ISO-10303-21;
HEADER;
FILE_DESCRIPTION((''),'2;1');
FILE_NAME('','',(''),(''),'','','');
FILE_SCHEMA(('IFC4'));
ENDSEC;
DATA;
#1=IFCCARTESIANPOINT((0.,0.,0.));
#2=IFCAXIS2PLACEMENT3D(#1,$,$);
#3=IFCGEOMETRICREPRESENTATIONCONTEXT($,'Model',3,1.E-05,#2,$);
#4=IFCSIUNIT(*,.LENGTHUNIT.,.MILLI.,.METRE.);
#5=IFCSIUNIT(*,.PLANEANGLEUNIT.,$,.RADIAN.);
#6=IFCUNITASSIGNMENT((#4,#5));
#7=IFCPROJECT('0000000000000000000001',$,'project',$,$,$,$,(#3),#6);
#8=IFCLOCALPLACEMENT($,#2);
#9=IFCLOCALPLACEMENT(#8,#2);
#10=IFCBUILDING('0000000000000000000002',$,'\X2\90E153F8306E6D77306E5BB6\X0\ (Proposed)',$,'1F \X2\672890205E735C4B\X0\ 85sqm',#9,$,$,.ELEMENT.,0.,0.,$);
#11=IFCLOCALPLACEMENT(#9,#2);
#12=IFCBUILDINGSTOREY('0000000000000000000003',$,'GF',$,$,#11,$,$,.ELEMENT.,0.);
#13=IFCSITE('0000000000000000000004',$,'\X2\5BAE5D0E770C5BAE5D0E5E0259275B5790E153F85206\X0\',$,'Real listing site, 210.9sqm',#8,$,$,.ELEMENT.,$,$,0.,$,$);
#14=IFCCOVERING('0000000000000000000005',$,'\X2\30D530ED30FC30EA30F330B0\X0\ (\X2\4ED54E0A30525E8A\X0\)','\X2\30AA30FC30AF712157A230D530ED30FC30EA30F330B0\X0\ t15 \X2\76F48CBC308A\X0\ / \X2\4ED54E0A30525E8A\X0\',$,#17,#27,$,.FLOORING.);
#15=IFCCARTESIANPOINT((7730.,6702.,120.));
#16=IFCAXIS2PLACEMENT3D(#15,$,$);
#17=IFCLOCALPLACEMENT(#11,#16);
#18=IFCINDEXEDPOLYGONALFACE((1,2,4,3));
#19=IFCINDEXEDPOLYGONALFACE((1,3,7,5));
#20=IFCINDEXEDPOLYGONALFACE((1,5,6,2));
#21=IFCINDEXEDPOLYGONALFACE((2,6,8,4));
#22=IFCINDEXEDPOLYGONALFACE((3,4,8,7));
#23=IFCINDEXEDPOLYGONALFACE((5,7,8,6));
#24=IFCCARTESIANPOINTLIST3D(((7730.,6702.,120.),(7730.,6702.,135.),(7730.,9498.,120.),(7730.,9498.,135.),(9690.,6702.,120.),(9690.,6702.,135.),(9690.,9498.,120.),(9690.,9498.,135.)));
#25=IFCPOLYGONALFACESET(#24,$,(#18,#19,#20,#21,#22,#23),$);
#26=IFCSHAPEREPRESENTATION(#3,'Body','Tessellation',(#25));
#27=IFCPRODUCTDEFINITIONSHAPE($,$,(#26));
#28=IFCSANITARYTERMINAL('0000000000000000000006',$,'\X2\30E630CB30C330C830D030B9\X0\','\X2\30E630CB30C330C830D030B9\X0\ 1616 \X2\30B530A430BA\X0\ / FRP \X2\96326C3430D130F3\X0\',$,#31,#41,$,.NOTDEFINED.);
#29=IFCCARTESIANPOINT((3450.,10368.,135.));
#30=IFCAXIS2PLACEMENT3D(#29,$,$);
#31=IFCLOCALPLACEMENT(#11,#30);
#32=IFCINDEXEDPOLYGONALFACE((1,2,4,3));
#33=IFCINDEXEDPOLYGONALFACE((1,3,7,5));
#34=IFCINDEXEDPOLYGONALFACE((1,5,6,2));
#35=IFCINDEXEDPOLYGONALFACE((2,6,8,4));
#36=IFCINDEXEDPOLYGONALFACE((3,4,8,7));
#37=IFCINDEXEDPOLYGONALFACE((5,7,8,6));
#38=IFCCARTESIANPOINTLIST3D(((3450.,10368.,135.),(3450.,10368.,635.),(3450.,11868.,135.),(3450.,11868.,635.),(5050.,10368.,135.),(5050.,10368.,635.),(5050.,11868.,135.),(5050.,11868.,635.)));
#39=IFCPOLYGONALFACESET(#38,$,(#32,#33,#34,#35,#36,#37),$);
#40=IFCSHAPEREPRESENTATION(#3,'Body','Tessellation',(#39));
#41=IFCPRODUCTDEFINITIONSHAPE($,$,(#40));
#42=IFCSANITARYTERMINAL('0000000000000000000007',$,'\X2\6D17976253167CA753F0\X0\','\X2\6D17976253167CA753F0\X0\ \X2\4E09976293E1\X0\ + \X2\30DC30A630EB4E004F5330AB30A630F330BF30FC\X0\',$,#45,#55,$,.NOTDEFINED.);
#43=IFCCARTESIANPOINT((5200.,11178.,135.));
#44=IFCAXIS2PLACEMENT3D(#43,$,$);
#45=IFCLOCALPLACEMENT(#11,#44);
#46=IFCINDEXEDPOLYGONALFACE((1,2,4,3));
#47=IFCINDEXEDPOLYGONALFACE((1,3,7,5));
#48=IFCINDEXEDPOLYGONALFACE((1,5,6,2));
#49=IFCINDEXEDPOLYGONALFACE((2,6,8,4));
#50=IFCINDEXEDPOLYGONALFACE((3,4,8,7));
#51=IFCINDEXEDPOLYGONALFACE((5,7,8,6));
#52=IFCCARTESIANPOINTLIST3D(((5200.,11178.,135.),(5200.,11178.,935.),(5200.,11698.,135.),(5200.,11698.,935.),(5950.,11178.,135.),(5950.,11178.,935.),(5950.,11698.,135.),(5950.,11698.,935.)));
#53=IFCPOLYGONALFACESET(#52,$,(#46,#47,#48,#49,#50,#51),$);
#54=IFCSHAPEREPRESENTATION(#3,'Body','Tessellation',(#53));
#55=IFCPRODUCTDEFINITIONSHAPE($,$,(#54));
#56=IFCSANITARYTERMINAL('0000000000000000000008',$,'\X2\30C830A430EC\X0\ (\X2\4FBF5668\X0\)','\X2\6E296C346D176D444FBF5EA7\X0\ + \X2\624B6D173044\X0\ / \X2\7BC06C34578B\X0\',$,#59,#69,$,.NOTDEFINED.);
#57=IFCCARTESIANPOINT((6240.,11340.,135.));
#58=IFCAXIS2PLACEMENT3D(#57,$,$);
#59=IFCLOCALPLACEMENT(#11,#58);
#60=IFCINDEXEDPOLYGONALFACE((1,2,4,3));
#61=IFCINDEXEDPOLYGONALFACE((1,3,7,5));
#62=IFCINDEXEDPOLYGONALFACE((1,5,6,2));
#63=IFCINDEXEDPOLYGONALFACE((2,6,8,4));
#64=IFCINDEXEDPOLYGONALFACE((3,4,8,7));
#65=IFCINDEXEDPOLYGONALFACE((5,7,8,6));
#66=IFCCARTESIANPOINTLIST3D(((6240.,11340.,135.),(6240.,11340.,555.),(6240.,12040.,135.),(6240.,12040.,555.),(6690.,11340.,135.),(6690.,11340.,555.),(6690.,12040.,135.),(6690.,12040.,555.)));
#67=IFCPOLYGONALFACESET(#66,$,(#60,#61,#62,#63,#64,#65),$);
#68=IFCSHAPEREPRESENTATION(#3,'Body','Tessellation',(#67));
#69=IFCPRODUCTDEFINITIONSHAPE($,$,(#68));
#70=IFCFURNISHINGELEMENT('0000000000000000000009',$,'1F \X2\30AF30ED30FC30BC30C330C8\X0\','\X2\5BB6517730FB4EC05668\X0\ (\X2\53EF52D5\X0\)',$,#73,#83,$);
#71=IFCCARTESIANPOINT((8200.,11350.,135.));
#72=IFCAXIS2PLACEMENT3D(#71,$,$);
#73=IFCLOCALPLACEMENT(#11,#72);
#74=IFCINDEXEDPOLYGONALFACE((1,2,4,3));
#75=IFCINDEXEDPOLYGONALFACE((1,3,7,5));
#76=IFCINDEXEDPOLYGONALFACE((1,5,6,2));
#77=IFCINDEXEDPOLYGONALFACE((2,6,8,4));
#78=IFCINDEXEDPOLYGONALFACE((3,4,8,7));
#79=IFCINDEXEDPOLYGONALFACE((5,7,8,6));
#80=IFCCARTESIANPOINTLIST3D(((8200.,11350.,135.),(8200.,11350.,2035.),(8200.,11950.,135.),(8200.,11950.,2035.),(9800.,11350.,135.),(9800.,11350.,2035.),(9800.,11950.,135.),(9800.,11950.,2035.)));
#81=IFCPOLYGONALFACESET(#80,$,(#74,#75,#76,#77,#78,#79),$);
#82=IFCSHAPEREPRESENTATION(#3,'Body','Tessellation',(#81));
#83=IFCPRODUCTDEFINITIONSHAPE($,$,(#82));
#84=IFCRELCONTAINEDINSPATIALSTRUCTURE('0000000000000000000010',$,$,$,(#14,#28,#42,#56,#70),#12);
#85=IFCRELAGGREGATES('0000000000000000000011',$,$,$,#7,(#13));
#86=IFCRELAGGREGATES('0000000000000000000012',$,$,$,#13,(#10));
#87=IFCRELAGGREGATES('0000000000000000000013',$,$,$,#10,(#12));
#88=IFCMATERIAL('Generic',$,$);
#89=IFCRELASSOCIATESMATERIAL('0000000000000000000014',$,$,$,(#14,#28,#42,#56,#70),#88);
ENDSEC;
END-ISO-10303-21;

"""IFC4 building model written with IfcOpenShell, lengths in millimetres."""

from ifc_helpers import new_model, si_unit, frame, frame_2d, origin, place, context, project, spatial, rectangle, extrude, material, element, save


model = new_model("IFC4")

# Units and contexts
model_context = context("Model", 3, precision=1e-05, world=origin())
ifc_project = project(units=[si_unit("LENGTHUNIT", "METRE", prefix="MILLI"), si_unit("PLANEANGLEUNIT", "RADIAN")], contexts=[model_context])

# Site, building, storey
site_placement = place(None, origin())
site = spatial("IfcSite", under=ifc_project, at=site_placement, Name="宮崎県宮崎市大字郡司分", ObjectType="Real listing site, 210.9sqm", CompositionType="ELEMENT", RefElevation=0.0)
building_placement = place(site_placement, origin())
building = spatial("IfcBuilding", under=site, at=building_placement, Name="郡司の海の家 (Proposed)", ObjectType="1F 木造平屋 85sqm", CompositionType="ELEMENT", ElevationOfRefHeight=0.0, ElevationOfTerrain=0.0)
storey_placement = place(building_placement, origin())
storey = spatial("IfcBuildingStorey", under=building, at=storey_placement, Name="GF", CompositionType="ELEMENT", Elevation=0.0)

# Covering
ifc_material_1 = material(Name="Generic")
covering_1_placement = place(storey_placement, frame((7730.0, 6702.0, 120.0)))
element("IfcCovering", 1, at=covering_1_placement, inside=storey, material=ifc_material_1, Name="フローリング (仕上げ床)", Description="オーク無垢フローリング t15 直貼り / 仕上げ床", PredefinedType="FLOORING", context=model_context, shape_type="SweptSolid", body=[
    extrude(rectangle(XDim=1960.0, YDim=2796.0, at=frame_2d((980.0, 1398.0))), frame((7730.0, 6702.0, 120.0)), (0.0, 0.0, 1.0), 15.0),
])

# Sanitary terminals
sanitary_terminal_1_placement = place(storey_placement, frame((3450.0, 10368.0, 135.0)))
element("IfcSanitaryTerminal", 2, at=sanitary_terminal_1_placement, inside=storey, material=ifc_material_1, Name="ユニットバス", Description="ユニットバス 1616 サイズ / FRP 防水パン", PredefinedType="NOTDEFINED", context=model_context, shape_type="SweptSolid", body=[
    extrude(rectangle(XDim=1600.0, YDim=1500.0, at=frame_2d((800.0, 750.0))), frame((3450.0, 10368.0, 135.0)), (0.0, 0.0, 1.0), 500.0),
])
sanitary_terminal_2_placement = place(storey_placement, frame((5200.0, 11178.0, 135.0)))
element("IfcSanitaryTerminal", 3, at=sanitary_terminal_2_placement, inside=storey, material=ifc_material_1, Name="洗面化粧台", Description="洗面化粧台 三面鏡 + ボウル一体カウンター", PredefinedType="NOTDEFINED", context=model_context, shape_type="SweptSolid", body=[
    extrude(rectangle(XDim=750.0, YDim=520.0, at=frame_2d((375.0, 260.0))), frame((5200.0, 11178.0, 135.0)), (0.0, 0.0, 1.0), 800.0),
])
sanitary_terminal_3_placement = place(storey_placement, frame((6240.0, 11340.0, 135.0)))
element("IfcSanitaryTerminal", 4, at=sanitary_terminal_3_placement, inside=storey, material=ifc_material_1, Name="トイレ (便器)", Description="温水洗浄便座 + 手洗い / 節水型", PredefinedType="NOTDEFINED", context=model_context, shape_type="SweptSolid", body=[
    extrude(rectangle(XDim=450.0, YDim=700.0, at=frame_2d((225.0, 350.0))), frame((6240.0, 11340.0, 135.0)), (0.0, 0.0, 1.0), 420.0),
])

# Furnishing element
furnishing_placement = place(storey_placement, frame((8200.0, 11350.0, 135.0)))
element("IfcFurnishingElement", 5, at=furnishing_placement, inside=storey, material=ifc_material_1, Name="1F クローゼット", Description="家具・什器 (可動)", context=model_context, shape_type="SweptSolid", body=[
    extrude(rectangle(XDim=1600.0, YDim=600.0, at=frame_2d((800.0, 300.0))), frame((8200.0, 11350.0, 135.0)), (0.0, 0.0, 1.0), 1900.0),
])

save(model, "model.ifc")
